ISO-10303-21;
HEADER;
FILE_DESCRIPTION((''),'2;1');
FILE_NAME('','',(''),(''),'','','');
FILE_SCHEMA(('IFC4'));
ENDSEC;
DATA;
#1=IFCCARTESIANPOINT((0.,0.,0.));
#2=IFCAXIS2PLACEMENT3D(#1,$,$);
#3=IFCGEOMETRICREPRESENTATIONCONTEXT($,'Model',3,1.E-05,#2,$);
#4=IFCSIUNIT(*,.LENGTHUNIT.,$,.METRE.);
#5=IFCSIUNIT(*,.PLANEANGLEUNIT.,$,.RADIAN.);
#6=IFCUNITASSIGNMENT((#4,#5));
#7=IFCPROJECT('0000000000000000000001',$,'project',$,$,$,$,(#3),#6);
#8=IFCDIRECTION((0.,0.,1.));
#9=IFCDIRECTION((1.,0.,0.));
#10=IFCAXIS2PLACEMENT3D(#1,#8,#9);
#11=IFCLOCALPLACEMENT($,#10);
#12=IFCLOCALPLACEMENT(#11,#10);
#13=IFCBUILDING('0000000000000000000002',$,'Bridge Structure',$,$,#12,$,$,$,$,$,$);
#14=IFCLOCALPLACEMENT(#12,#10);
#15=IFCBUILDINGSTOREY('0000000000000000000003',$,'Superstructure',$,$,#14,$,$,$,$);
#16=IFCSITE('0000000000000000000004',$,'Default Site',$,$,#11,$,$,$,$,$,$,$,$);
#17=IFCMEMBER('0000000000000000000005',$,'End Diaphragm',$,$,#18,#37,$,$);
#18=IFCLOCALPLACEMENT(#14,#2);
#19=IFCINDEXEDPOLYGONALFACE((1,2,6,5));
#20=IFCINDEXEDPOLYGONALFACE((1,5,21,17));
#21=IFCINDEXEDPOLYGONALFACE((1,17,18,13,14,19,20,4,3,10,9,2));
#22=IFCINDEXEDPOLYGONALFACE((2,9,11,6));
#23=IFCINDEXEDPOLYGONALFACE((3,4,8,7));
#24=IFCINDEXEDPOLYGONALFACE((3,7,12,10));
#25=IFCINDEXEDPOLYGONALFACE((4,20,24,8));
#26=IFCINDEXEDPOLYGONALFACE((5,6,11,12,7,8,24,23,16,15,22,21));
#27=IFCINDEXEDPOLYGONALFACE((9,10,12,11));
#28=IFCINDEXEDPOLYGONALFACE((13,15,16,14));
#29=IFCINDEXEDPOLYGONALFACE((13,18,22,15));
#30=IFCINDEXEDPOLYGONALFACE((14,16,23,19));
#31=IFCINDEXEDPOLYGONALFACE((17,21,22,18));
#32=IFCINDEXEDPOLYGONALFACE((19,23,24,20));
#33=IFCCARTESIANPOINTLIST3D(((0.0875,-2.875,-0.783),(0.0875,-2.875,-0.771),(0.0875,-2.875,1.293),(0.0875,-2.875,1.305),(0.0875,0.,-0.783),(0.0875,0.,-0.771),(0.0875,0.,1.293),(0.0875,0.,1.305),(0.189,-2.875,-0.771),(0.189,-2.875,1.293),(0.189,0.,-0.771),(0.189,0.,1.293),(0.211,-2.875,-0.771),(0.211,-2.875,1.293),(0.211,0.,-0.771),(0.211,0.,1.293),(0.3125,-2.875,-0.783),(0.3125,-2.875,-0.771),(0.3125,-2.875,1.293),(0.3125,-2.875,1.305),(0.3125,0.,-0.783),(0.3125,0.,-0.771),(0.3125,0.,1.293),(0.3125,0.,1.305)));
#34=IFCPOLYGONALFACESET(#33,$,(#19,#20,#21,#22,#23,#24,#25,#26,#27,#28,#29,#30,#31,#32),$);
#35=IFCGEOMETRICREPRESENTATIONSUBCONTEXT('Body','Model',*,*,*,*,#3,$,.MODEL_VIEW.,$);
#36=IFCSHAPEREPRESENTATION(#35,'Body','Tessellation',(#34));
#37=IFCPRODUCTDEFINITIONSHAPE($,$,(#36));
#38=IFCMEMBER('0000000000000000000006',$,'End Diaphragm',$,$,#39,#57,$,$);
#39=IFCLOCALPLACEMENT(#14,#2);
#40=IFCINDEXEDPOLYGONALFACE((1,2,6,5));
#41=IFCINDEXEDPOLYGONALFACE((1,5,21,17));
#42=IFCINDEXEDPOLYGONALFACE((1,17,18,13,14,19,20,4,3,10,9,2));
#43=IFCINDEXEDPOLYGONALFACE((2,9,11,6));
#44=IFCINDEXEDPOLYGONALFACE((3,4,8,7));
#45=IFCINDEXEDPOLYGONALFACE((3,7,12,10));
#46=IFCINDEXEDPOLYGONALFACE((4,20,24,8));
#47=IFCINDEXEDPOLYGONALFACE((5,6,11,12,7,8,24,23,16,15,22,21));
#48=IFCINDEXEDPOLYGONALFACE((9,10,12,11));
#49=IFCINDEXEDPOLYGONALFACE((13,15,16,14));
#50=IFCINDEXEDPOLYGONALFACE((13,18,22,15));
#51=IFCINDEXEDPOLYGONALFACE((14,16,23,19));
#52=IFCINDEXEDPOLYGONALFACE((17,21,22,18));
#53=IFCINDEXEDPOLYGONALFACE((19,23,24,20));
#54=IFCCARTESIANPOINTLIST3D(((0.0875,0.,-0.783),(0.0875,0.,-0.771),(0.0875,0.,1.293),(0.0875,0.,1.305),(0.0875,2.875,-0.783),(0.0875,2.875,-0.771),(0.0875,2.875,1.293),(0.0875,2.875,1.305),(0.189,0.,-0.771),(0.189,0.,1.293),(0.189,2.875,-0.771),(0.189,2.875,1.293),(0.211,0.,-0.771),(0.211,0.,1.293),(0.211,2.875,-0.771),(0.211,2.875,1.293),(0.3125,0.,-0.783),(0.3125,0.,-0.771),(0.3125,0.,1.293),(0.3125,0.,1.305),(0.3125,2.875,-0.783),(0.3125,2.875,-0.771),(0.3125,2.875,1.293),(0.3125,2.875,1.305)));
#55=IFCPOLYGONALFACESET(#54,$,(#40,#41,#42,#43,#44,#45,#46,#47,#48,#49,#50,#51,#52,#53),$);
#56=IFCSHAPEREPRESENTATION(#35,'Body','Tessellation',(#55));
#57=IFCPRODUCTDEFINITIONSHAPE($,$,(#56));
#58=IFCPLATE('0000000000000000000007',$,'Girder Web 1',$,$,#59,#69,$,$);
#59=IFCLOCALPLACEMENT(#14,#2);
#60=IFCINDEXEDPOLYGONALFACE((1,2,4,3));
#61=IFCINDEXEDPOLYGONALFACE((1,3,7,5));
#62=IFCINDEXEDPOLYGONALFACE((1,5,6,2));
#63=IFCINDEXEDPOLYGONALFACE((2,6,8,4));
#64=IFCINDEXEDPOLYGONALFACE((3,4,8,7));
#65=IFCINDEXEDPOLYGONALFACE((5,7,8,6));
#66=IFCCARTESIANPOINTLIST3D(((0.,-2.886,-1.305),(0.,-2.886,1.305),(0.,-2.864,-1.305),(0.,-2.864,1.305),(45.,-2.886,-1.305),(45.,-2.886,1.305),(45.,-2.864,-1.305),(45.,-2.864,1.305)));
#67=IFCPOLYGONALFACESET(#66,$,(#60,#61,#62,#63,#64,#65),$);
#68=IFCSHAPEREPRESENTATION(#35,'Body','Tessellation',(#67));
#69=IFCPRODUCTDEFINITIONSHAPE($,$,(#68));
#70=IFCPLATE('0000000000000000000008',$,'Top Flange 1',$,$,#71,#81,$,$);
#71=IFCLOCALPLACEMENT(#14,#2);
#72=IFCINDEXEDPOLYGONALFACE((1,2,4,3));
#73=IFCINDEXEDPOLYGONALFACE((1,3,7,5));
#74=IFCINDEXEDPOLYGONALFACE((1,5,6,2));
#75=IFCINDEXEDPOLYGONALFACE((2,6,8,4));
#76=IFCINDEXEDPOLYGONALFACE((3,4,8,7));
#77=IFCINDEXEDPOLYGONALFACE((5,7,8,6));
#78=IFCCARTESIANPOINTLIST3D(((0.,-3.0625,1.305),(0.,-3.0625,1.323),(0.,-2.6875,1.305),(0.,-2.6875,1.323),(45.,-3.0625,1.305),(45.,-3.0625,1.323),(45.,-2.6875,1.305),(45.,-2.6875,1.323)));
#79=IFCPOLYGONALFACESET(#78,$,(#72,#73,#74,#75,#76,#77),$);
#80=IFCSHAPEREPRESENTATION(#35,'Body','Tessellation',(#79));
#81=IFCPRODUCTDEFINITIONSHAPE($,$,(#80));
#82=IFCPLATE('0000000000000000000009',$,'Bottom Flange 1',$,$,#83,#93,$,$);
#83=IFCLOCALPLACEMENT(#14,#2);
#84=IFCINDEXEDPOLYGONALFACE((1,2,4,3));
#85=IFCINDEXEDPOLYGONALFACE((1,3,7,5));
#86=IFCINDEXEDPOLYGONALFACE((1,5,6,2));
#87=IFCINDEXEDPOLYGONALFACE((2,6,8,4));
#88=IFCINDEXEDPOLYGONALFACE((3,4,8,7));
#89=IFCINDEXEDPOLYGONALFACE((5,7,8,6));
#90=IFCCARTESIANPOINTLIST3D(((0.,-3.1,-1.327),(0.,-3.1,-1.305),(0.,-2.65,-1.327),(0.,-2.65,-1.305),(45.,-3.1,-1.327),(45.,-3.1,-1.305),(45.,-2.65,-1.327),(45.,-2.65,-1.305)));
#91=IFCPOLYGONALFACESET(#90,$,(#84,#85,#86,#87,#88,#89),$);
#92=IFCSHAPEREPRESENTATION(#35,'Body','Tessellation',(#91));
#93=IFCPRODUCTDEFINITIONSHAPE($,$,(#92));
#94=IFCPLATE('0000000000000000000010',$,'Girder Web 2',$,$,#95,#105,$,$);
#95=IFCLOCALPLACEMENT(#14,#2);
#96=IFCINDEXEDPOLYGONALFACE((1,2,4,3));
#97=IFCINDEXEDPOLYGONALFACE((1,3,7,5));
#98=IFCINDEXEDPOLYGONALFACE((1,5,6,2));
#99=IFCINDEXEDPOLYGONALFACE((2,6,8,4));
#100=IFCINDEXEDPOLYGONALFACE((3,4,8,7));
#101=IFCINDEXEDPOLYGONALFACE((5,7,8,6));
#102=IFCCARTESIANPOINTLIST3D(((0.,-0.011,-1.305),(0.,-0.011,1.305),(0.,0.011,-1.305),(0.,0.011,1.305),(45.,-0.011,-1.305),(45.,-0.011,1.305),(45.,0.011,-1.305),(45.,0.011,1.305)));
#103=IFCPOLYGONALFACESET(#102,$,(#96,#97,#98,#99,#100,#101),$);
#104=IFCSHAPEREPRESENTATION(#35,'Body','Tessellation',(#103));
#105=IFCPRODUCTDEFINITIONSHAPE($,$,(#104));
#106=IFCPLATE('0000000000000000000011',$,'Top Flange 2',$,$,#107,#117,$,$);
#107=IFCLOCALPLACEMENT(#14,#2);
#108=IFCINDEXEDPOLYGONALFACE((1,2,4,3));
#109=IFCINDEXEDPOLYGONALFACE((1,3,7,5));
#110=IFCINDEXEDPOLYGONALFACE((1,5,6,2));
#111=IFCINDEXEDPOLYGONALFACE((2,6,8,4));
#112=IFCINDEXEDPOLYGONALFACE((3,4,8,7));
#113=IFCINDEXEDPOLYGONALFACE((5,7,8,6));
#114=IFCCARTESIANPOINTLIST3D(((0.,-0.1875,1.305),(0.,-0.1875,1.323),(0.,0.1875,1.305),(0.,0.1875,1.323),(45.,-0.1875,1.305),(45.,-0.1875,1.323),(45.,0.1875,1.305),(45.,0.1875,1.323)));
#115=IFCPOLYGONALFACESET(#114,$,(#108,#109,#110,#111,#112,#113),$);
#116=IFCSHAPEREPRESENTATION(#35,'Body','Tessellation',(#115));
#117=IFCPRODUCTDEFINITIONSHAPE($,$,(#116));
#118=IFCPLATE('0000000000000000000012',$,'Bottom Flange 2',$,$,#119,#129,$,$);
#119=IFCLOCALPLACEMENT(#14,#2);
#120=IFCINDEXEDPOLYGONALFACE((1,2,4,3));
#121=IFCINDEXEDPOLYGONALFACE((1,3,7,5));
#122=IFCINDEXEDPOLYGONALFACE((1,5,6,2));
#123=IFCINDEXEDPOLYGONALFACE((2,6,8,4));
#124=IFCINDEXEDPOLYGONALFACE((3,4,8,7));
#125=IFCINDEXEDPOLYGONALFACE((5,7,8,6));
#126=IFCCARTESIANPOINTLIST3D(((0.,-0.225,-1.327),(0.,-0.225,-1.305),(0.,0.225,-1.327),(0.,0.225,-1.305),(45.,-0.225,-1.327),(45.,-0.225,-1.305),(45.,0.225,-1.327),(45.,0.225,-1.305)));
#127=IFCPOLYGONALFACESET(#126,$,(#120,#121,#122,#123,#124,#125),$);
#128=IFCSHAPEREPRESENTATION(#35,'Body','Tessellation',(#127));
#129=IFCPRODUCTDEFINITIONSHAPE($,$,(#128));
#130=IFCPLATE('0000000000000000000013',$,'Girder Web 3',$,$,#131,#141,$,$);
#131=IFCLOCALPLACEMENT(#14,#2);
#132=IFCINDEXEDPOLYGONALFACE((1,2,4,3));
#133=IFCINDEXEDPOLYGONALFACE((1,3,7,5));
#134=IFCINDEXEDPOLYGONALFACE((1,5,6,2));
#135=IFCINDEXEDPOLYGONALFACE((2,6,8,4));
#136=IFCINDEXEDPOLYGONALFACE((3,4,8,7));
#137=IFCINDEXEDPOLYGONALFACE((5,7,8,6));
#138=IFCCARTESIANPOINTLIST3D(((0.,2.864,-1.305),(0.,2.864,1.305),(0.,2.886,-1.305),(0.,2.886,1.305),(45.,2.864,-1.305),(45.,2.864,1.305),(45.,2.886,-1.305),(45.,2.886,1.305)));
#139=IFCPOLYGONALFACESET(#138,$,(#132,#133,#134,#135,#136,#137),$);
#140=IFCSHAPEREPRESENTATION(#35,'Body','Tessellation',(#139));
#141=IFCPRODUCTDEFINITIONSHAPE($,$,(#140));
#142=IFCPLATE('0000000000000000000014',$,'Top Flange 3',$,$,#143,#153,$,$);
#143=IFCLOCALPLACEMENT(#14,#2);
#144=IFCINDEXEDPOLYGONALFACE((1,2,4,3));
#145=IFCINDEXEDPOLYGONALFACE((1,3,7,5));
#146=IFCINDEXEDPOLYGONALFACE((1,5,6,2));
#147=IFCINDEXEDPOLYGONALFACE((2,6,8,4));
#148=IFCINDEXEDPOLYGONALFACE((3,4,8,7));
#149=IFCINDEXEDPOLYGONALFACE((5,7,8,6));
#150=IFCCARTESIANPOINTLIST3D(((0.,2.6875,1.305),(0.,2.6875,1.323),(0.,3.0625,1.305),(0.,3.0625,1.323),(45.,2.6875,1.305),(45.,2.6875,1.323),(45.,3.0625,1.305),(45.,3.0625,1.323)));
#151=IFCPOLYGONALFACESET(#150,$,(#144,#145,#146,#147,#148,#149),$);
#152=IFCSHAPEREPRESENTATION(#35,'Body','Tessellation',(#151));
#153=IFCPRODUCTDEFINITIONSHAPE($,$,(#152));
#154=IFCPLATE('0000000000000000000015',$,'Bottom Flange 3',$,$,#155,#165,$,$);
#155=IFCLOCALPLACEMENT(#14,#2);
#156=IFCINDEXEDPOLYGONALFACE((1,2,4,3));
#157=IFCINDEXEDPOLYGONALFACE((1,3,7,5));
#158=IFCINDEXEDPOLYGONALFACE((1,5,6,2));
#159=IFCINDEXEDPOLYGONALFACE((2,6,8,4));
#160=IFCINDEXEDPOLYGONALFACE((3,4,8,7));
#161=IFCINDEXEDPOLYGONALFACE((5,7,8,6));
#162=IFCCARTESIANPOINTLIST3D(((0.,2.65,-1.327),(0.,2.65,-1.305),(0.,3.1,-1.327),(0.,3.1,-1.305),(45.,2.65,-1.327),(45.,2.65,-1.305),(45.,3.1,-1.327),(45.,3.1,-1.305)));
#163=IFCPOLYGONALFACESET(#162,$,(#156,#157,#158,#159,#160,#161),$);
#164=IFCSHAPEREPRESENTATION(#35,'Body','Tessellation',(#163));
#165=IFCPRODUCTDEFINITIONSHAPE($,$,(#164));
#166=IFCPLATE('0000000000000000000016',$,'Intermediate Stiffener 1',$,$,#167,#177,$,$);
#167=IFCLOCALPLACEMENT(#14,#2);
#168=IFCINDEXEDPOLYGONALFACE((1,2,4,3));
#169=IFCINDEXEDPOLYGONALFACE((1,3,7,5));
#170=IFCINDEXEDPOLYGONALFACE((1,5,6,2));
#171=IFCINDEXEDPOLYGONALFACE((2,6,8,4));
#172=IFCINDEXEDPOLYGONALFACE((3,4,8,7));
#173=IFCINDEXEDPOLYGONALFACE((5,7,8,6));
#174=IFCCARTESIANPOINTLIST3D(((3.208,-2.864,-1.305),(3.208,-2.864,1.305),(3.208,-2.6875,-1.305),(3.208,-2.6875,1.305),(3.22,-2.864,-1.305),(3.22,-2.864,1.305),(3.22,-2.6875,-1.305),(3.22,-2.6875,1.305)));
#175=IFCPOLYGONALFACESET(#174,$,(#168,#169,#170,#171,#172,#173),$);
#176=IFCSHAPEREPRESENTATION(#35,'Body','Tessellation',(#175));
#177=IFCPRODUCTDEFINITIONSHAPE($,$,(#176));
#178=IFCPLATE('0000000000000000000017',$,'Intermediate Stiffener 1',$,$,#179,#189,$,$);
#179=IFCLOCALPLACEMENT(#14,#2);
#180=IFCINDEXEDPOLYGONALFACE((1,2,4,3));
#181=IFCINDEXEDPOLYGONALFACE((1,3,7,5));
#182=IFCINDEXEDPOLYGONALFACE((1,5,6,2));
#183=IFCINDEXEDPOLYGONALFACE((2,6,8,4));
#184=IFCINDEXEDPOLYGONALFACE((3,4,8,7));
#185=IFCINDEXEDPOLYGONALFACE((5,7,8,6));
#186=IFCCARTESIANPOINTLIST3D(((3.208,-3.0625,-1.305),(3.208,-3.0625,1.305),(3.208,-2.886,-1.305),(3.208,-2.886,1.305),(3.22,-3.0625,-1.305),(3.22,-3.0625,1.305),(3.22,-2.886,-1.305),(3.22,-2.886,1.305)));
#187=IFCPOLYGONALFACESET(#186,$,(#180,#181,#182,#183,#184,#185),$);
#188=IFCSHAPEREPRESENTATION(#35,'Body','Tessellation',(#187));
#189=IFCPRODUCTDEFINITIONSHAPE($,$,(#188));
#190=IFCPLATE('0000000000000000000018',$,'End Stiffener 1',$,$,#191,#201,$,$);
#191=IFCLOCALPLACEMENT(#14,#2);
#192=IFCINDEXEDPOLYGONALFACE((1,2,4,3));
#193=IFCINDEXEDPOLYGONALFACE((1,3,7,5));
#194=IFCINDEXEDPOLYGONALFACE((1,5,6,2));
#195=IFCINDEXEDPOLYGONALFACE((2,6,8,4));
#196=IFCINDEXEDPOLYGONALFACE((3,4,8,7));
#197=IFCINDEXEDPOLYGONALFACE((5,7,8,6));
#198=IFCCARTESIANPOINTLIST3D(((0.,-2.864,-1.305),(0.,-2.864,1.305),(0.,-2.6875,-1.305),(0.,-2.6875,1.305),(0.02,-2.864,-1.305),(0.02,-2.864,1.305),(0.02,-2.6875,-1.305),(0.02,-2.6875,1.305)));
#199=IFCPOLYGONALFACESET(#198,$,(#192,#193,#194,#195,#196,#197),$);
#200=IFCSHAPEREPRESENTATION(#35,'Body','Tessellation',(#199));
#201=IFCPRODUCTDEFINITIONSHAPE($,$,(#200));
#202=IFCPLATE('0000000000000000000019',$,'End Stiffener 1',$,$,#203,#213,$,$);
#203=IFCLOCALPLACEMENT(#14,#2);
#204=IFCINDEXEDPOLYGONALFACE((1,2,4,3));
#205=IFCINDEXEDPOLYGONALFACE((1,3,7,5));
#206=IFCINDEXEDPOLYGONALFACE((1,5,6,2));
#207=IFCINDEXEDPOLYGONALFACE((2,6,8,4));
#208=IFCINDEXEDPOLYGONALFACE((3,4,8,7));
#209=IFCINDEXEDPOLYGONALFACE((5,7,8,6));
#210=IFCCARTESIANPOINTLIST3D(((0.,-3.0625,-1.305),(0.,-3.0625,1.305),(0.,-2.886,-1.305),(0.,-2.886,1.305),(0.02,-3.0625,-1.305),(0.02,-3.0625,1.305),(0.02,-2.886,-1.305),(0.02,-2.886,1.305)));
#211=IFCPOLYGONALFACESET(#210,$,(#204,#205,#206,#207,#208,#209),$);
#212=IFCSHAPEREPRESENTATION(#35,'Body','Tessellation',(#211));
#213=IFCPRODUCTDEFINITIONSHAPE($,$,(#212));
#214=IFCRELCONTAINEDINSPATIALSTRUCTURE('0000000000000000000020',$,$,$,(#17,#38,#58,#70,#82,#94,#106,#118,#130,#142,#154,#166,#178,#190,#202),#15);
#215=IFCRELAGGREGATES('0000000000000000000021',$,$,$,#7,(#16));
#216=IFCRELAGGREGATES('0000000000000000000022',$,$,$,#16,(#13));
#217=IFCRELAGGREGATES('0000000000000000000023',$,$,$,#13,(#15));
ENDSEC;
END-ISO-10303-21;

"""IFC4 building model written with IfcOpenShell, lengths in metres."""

from ifc_helpers import new_model, si_unit, frame, origin, origin_with_axes, origin_2d_with_axis, place, context, subcontext, project, spatial, rectangle, i_section, extrude, element, save


model = new_model("IFC4")

# Units and contexts
model_context = context("Model", 3, precision=1e-05, world=origin())
body_context = subcontext(model_context, "Body", "Model", "MODEL_VIEW")
ifc_project = project(units=[si_unit("LENGTHUNIT", "METRE"), si_unit("PLANEANGLEUNIT", "RADIAN")], contexts=[model_context])

# Site, building, storey
site_placement = place(None, origin_with_axes())
site = spatial("IfcSite", under=ifc_project, at=site_placement, Name="Default Site")
building_placement = place(site_placement, origin_with_axes())
building = spatial("IfcBuilding", under=site, at=building_placement, Name="Bridge Structure")
storey_placement = place(building_placement, origin_with_axes())
storey = spatial("IfcBuildingStorey", under=building, at=storey_placement, Name="Superstructure")

# Members
for number, where, z_axis, x_axis, name in (
    (1, (0.2, -2.875, 0.261), (0.0, 1.0, 0.0), (-1.0, 0.0, 0.0), "End Diaphragm"),
    (2, (0.2, 0.0, 0.261), (0.0, 1.0, 0.0), (-1.0, 0.0, 0.0), "End Diaphragm"),
):
    element("IfcMember", number, at=place(storey_placement, frame(where, z_axis=z_axis, x_axis=x_axis)), inside=storey, Name=name, context=body_context, shape_type="SweptSolid", body=[
        extrude(i_section(OverallWidth=0.225, OverallDepth=2.088, WebThickness=0.022, FlangeThickness=0.012, at=origin_2d_with_axis()), origin_with_axes(), (0.0, 0.0, 1.0), 2.875),
    ])

# Plates
plate_1_placement = place(storey_placement, frame((0.0, -2.875, 0.0), z_axis=(1.0, 0.0, 0.0), x_axis=(0.0, 1.0, 0.0)))
element("IfcPlate", 3, at=plate_1_placement, inside=storey, Name="Girder Web 1", context=body_context, shape_type="SweptSolid", body=[
    extrude(rectangle(XDim=0.022, YDim=2.61, at=origin_2d_with_axis()), origin_with_axes(), (0.0, 0.0, 1.0), 45.0),
])
plate_2_placement = place(storey_placement, frame((0.0, -2.875, 1.314), z_axis=(1.0, 0.0, 0.0), x_axis=(0.0, 1.0, 0.0)))
element("IfcPlate", 4, at=plate_2_placement, inside=storey, Name="Top Flange 1", context=body_context, shape_type="SweptSolid", body=[
    extrude(rectangle(XDim=0.375, YDim=0.018, at=origin_2d_with_axis()), origin_with_axes(), (0.0, 0.0, 1.0), 45.0),
])
plate_3_placement = place(storey_placement, frame((0.0, -2.875, -1.316), z_axis=(1.0, 0.0, 0.0), x_axis=(0.0, 1.0, 0.0)))
element("IfcPlate", 5, at=plate_3_placement, inside=storey, Name="Bottom Flange 1", context=body_context, shape_type="SweptSolid", body=[
    extrude(rectangle(XDim=0.45, YDim=0.022, at=origin_2d_with_axis()), origin_with_axes(), (0.0, 0.0, 1.0), 45.0),
])
plate_4_placement = place(storey_placement, frame((0.0, 0.0, 0.0), z_axis=(1.0, 0.0, 0.0), x_axis=(0.0, 1.0, 0.0)))
element("IfcPlate", 6, at=plate_4_placement, inside=storey, Name="Girder Web 2", context=body_context, shape_type="SweptSolid", body=[
    extrude(rectangle(XDim=0.022, YDim=2.61, at=origin_2d_with_axis()), origin_with_axes(), (0.0, 0.0, 1.0), 45.0),
])
plate_5_placement = place(storey_placement, frame((0.0, 0.0, 1.314), z_axis=(1.0, 0.0, 0.0), x_axis=(0.0, 1.0, 0.0)))
element("IfcPlate", 7, at=plate_5_placement, inside=storey, Name="Top Flange 2", context=body_context, shape_type="SweptSolid", body=[
    extrude(rectangle(XDim=0.375, YDim=0.018, at=origin_2d_with_axis()), origin_with_axes(), (0.0, 0.0, 1.0), 45.0),
])
plate_6_placement = place(storey_placement, frame((0.0, 0.0, -1.316), z_axis=(1.0, 0.0, 0.0), x_axis=(0.0, 1.0, 0.0)))
element("IfcPlate", 8, at=plate_6_placement, inside=storey, Name="Bottom Flange 2", context=body_context, shape_type="SweptSolid", body=[
    extrude(rectangle(XDim=0.45, YDim=0.022, at=origin_2d_with_axis()), origin_with_axes(), (0.0, 0.0, 1.0), 45.0),
])
plate_7_placement = place(storey_placement, frame((0.0, 2.875, 0.0), z_axis=(1.0, 0.0, 0.0), x_axis=(0.0, 1.0, 0.0)))
element("IfcPlate", 9, at=plate_7_placement, inside=storey, Name="Girder Web 3", context=body_context, shape_type="SweptSolid", body=[
    extrude(rectangle(XDim=0.022, YDim=2.61, at=origin_2d_with_axis()), origin_with_axes(), (0.0, 0.0, 1.0), 45.0),
])
plate_8_placement = place(storey_placement, frame((0.0, 2.875, 1.314), z_axis=(1.0, 0.0, 0.0), x_axis=(0.0, 1.0, 0.0)))
element("IfcPlate", 10, at=plate_8_placement, inside=storey, Name="Top Flange 3", context=body_context, shape_type="SweptSolid", body=[
    extrude(rectangle(XDim=0.375, YDim=0.018, at=origin_2d_with_axis()), origin_with_axes(), (0.0, 0.0, 1.0), 45.0),
])
plate_9_placement = place(storey_placement, frame((0.0, 2.875, -1.316), z_axis=(1.0, 0.0, 0.0), x_axis=(0.0, 1.0, 0.0)))
element("IfcPlate", 11, at=plate_9_placement, inside=storey, Name="Bottom Flange 3", context=body_context, shape_type="SweptSolid", body=[
    extrude(rectangle(XDim=0.45, YDim=0.022, at=origin_2d_with_axis()), origin_with_axes(), (0.0, 0.0, 1.0), 45.0),
])
for number, where, z_axis, x_axis, name in (
    (12, (3.214, -2.7757, -1.305), (0.0, 0.0, 1.0), (1.0, 0.0, 0.0), "Intermediate Stiffener 1"),
    (13, (3.214, -2.9743, -1.305), (0.0, 0.0, 1.0), (1.0, 0.0, 0.0), "Intermediate Stiffener 1"),
):
    element("IfcPlate", number, at=place(storey_placement, frame(where, z_axis=z_axis, x_axis=x_axis)), inside=storey, Name=name, context=body_context, shape_type="SweptSolid", body=[
        extrude(rectangle(XDim=0.012, YDim=0.1765, at=origin_2d_with_axis()), origin_with_axes(), (0.0, 0.0, 1.0), 2.61),
    ])
for number, where, z_axis, x_axis, name in (
    (14, (0.01, -2.7757, -1.305), (0.0, 0.0, 1.0), (1.0, 0.0, 0.0), "End Stiffener 1"),
    (15, (0.01, -2.9743, -1.305), (0.0, 0.0, 1.0), (1.0, 0.0, 0.0), "End Stiffener 1"),
):
    element("IfcPlate", number, at=place(storey_placement, frame(where, z_axis=z_axis, x_axis=x_axis)), inside=storey, Name=name, context=body_context, shape_type="SweptSolid", body=[
        extrude(rectangle(XDim=0.02, YDim=0.1765, at=origin_2d_with_axis()), origin_with_axes(), (0.0, 0.0, 1.0), 2.61),
    ])

save(model, "model.ifc")
